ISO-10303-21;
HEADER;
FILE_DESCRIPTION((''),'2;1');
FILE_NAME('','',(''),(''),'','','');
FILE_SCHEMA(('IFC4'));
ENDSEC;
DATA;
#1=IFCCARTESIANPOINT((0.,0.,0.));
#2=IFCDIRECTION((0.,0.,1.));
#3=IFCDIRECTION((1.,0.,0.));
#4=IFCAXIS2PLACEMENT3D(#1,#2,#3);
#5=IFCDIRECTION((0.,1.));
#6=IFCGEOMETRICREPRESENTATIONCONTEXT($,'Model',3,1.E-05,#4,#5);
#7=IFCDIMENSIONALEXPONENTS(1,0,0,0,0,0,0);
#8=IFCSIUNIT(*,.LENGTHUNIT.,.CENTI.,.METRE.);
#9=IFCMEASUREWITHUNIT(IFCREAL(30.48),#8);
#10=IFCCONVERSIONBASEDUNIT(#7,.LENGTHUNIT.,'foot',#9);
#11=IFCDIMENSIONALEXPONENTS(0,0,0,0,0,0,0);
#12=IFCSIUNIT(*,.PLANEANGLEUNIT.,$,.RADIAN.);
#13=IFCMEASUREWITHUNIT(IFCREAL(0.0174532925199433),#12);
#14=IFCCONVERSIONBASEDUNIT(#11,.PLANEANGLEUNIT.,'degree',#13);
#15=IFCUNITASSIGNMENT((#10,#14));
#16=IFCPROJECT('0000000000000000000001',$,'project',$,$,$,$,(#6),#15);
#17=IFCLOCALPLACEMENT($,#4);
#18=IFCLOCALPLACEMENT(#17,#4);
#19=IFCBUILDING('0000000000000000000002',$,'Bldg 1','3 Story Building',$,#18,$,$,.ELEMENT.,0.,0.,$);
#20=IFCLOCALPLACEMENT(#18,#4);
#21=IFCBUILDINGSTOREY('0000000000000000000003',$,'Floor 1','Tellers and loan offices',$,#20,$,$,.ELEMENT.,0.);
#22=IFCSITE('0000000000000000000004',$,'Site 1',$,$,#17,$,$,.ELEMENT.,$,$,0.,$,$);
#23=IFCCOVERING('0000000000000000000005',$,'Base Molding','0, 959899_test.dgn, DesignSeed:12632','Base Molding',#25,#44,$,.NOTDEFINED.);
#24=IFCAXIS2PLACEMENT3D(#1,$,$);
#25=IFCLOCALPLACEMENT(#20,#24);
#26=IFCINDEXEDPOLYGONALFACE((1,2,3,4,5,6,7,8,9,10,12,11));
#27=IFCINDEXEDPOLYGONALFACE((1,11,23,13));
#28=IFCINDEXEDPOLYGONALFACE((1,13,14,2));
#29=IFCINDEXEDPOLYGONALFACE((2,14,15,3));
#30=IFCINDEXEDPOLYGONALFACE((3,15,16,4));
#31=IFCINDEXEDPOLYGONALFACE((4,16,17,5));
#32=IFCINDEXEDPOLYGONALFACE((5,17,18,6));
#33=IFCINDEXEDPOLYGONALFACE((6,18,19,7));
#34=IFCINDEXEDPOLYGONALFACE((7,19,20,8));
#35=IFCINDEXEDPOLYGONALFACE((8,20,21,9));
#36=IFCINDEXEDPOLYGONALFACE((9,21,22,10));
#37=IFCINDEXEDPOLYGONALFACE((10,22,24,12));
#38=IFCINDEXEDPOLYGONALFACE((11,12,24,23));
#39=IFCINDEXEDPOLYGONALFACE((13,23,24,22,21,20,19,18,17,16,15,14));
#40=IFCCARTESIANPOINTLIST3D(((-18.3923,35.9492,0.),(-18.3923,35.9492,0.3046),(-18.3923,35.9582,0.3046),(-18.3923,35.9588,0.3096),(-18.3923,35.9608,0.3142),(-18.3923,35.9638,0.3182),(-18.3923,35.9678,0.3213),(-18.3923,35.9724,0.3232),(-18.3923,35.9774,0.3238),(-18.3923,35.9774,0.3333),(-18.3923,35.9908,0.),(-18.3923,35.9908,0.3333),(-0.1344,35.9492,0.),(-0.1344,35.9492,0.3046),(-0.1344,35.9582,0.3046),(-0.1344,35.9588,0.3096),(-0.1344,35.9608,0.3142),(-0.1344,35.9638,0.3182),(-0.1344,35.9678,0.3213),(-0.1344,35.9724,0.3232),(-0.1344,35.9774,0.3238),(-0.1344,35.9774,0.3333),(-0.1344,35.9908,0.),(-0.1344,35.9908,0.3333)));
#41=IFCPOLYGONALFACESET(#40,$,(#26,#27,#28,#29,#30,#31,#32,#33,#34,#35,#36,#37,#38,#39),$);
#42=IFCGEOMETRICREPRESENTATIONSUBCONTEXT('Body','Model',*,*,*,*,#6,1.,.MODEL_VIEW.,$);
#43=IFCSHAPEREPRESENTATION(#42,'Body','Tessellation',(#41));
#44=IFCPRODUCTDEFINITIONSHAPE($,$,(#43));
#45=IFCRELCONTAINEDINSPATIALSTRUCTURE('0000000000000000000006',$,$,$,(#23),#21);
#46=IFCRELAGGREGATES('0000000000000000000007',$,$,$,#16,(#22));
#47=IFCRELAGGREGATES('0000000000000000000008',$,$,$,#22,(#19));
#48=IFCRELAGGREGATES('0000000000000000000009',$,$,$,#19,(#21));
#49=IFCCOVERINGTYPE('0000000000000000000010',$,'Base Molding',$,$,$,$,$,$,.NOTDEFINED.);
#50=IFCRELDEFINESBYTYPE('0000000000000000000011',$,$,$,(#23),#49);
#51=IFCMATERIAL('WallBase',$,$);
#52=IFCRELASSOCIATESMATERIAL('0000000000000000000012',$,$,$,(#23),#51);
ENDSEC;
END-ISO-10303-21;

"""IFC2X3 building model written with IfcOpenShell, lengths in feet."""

from ifc_helpers import new_model, entity, si_unit, converted_unit, direction, frame, frame_2d, origin_with_axes, place, context, subcontext, project, spatial, polyline, circle_curve, parameter, trimmed, segment, composite_curve, outline, extrude, material, type_object, element, save


model = new_model("IFC2X3")

# Units and contexts
model_context = context("Model", 3, precision=1e-05, world=origin_with_axes(), true_north=direction((0.0, 1.0)))
body_context = subcontext(model_context, "Body", "Model", "MODEL_VIEW", scale=1.0)
ifc_project = project(units=[converted_unit("LENGTHUNIT", "foot", entity("IfcReal", 30.48), si_unit("LENGTHUNIT", "METRE", prefix="CENTI"), dimensions=[1, 0, 0, 0, 0, 0, 0]), converted_unit("PLANEANGLEUNIT", "degree", entity("IfcReal", 0.0174532925199433), si_unit("PLANEANGLEUNIT", "RADIAN"), dimensions=[0, 0, 0, 0, 0, 0, 0])], contexts=[model_context])

# Site, building, storey
site_placement = place(None, origin_with_axes())
site = spatial("IfcSite", under=ifc_project, at=site_placement, Name="Site 1", CompositionType="ELEMENT", RefElevation=0.0)
building_placement = place(site_placement, origin_with_axes())
building = spatial("IfcBuilding", under=site, at=building_placement, Name="Bldg 1", Description="3 Story Building", CompositionType="ELEMENT", ElevationOfRefHeight=0.0, ElevationOfTerrain=0.0)
storey_placement = place(building_placement, origin_with_axes())
storey = spatial("IfcBuildingStorey", under=building, at=storey_placement, Name="Floor 1", Description="Tellers and loan offices", CompositionType="ELEMENT", Elevation=0.0)

# Covering
ifc_material = material(Name="WallBase")
covering_type = type_object("IfcCoveringType", Name="Base Molding", PredefinedType="NOTDEFINED")
covering_1_placement = place(storey_placement, frame((-18.3923, 35.9774, 0.3238), z_axis=(1.0, 0.0, 0.0), x_axis=(0.0, -1.0, 0.0)))
element("IfcCovering", 1, at=covering_1_placement, inside=storey, type_object=covering_type, material=ifc_material, Name="Base Molding", Description="0, 959899_test.dgn, DesignSeed:12632", ObjectType="Base Molding", PredefinedType="NOTDEFINED", context=body_context, shape_type="SweptSolid", body=[
    extrude(outline(composite_curve([segment(trimmed(circle_curve(frame_2d((0.0, 0.0192), x_axis=(1.0, 0.0)), 0.0192), [parameter(270.0)], [parameter(360.0)], True, "PARAMETER"), True, "CONTINUOUS"), segment(polyline([(0.0192, 0.0192), (0.0283, 0.0192)]), True, "CONTINUOUS"), segment(polyline([(0.0283, 0.0192), (0.0283, 0.3238)]), True, "CONTINUOUS"), segment(polyline([(0.0283, 0.3238), (-0.0134, 0.3238)]), True, "CONTINUOUS"), segment(polyline([(-0.0134, 0.3238), (-0.0134, -0.0095)]), True, "CONTINUOUS"), segment(polyline([(-0.0134, -0.0095), (0.0, -0.0095)]), True, "CONTINUOUS"), segment(polyline([(0.0, -0.0095), (0.0, 0.0)]), True, "CONTINUOUS")], self_intersect=False)), origin_with_axes(), (0.0, 0.0, 1.0), 18.2579),
])

save(model, "model.ifc")
